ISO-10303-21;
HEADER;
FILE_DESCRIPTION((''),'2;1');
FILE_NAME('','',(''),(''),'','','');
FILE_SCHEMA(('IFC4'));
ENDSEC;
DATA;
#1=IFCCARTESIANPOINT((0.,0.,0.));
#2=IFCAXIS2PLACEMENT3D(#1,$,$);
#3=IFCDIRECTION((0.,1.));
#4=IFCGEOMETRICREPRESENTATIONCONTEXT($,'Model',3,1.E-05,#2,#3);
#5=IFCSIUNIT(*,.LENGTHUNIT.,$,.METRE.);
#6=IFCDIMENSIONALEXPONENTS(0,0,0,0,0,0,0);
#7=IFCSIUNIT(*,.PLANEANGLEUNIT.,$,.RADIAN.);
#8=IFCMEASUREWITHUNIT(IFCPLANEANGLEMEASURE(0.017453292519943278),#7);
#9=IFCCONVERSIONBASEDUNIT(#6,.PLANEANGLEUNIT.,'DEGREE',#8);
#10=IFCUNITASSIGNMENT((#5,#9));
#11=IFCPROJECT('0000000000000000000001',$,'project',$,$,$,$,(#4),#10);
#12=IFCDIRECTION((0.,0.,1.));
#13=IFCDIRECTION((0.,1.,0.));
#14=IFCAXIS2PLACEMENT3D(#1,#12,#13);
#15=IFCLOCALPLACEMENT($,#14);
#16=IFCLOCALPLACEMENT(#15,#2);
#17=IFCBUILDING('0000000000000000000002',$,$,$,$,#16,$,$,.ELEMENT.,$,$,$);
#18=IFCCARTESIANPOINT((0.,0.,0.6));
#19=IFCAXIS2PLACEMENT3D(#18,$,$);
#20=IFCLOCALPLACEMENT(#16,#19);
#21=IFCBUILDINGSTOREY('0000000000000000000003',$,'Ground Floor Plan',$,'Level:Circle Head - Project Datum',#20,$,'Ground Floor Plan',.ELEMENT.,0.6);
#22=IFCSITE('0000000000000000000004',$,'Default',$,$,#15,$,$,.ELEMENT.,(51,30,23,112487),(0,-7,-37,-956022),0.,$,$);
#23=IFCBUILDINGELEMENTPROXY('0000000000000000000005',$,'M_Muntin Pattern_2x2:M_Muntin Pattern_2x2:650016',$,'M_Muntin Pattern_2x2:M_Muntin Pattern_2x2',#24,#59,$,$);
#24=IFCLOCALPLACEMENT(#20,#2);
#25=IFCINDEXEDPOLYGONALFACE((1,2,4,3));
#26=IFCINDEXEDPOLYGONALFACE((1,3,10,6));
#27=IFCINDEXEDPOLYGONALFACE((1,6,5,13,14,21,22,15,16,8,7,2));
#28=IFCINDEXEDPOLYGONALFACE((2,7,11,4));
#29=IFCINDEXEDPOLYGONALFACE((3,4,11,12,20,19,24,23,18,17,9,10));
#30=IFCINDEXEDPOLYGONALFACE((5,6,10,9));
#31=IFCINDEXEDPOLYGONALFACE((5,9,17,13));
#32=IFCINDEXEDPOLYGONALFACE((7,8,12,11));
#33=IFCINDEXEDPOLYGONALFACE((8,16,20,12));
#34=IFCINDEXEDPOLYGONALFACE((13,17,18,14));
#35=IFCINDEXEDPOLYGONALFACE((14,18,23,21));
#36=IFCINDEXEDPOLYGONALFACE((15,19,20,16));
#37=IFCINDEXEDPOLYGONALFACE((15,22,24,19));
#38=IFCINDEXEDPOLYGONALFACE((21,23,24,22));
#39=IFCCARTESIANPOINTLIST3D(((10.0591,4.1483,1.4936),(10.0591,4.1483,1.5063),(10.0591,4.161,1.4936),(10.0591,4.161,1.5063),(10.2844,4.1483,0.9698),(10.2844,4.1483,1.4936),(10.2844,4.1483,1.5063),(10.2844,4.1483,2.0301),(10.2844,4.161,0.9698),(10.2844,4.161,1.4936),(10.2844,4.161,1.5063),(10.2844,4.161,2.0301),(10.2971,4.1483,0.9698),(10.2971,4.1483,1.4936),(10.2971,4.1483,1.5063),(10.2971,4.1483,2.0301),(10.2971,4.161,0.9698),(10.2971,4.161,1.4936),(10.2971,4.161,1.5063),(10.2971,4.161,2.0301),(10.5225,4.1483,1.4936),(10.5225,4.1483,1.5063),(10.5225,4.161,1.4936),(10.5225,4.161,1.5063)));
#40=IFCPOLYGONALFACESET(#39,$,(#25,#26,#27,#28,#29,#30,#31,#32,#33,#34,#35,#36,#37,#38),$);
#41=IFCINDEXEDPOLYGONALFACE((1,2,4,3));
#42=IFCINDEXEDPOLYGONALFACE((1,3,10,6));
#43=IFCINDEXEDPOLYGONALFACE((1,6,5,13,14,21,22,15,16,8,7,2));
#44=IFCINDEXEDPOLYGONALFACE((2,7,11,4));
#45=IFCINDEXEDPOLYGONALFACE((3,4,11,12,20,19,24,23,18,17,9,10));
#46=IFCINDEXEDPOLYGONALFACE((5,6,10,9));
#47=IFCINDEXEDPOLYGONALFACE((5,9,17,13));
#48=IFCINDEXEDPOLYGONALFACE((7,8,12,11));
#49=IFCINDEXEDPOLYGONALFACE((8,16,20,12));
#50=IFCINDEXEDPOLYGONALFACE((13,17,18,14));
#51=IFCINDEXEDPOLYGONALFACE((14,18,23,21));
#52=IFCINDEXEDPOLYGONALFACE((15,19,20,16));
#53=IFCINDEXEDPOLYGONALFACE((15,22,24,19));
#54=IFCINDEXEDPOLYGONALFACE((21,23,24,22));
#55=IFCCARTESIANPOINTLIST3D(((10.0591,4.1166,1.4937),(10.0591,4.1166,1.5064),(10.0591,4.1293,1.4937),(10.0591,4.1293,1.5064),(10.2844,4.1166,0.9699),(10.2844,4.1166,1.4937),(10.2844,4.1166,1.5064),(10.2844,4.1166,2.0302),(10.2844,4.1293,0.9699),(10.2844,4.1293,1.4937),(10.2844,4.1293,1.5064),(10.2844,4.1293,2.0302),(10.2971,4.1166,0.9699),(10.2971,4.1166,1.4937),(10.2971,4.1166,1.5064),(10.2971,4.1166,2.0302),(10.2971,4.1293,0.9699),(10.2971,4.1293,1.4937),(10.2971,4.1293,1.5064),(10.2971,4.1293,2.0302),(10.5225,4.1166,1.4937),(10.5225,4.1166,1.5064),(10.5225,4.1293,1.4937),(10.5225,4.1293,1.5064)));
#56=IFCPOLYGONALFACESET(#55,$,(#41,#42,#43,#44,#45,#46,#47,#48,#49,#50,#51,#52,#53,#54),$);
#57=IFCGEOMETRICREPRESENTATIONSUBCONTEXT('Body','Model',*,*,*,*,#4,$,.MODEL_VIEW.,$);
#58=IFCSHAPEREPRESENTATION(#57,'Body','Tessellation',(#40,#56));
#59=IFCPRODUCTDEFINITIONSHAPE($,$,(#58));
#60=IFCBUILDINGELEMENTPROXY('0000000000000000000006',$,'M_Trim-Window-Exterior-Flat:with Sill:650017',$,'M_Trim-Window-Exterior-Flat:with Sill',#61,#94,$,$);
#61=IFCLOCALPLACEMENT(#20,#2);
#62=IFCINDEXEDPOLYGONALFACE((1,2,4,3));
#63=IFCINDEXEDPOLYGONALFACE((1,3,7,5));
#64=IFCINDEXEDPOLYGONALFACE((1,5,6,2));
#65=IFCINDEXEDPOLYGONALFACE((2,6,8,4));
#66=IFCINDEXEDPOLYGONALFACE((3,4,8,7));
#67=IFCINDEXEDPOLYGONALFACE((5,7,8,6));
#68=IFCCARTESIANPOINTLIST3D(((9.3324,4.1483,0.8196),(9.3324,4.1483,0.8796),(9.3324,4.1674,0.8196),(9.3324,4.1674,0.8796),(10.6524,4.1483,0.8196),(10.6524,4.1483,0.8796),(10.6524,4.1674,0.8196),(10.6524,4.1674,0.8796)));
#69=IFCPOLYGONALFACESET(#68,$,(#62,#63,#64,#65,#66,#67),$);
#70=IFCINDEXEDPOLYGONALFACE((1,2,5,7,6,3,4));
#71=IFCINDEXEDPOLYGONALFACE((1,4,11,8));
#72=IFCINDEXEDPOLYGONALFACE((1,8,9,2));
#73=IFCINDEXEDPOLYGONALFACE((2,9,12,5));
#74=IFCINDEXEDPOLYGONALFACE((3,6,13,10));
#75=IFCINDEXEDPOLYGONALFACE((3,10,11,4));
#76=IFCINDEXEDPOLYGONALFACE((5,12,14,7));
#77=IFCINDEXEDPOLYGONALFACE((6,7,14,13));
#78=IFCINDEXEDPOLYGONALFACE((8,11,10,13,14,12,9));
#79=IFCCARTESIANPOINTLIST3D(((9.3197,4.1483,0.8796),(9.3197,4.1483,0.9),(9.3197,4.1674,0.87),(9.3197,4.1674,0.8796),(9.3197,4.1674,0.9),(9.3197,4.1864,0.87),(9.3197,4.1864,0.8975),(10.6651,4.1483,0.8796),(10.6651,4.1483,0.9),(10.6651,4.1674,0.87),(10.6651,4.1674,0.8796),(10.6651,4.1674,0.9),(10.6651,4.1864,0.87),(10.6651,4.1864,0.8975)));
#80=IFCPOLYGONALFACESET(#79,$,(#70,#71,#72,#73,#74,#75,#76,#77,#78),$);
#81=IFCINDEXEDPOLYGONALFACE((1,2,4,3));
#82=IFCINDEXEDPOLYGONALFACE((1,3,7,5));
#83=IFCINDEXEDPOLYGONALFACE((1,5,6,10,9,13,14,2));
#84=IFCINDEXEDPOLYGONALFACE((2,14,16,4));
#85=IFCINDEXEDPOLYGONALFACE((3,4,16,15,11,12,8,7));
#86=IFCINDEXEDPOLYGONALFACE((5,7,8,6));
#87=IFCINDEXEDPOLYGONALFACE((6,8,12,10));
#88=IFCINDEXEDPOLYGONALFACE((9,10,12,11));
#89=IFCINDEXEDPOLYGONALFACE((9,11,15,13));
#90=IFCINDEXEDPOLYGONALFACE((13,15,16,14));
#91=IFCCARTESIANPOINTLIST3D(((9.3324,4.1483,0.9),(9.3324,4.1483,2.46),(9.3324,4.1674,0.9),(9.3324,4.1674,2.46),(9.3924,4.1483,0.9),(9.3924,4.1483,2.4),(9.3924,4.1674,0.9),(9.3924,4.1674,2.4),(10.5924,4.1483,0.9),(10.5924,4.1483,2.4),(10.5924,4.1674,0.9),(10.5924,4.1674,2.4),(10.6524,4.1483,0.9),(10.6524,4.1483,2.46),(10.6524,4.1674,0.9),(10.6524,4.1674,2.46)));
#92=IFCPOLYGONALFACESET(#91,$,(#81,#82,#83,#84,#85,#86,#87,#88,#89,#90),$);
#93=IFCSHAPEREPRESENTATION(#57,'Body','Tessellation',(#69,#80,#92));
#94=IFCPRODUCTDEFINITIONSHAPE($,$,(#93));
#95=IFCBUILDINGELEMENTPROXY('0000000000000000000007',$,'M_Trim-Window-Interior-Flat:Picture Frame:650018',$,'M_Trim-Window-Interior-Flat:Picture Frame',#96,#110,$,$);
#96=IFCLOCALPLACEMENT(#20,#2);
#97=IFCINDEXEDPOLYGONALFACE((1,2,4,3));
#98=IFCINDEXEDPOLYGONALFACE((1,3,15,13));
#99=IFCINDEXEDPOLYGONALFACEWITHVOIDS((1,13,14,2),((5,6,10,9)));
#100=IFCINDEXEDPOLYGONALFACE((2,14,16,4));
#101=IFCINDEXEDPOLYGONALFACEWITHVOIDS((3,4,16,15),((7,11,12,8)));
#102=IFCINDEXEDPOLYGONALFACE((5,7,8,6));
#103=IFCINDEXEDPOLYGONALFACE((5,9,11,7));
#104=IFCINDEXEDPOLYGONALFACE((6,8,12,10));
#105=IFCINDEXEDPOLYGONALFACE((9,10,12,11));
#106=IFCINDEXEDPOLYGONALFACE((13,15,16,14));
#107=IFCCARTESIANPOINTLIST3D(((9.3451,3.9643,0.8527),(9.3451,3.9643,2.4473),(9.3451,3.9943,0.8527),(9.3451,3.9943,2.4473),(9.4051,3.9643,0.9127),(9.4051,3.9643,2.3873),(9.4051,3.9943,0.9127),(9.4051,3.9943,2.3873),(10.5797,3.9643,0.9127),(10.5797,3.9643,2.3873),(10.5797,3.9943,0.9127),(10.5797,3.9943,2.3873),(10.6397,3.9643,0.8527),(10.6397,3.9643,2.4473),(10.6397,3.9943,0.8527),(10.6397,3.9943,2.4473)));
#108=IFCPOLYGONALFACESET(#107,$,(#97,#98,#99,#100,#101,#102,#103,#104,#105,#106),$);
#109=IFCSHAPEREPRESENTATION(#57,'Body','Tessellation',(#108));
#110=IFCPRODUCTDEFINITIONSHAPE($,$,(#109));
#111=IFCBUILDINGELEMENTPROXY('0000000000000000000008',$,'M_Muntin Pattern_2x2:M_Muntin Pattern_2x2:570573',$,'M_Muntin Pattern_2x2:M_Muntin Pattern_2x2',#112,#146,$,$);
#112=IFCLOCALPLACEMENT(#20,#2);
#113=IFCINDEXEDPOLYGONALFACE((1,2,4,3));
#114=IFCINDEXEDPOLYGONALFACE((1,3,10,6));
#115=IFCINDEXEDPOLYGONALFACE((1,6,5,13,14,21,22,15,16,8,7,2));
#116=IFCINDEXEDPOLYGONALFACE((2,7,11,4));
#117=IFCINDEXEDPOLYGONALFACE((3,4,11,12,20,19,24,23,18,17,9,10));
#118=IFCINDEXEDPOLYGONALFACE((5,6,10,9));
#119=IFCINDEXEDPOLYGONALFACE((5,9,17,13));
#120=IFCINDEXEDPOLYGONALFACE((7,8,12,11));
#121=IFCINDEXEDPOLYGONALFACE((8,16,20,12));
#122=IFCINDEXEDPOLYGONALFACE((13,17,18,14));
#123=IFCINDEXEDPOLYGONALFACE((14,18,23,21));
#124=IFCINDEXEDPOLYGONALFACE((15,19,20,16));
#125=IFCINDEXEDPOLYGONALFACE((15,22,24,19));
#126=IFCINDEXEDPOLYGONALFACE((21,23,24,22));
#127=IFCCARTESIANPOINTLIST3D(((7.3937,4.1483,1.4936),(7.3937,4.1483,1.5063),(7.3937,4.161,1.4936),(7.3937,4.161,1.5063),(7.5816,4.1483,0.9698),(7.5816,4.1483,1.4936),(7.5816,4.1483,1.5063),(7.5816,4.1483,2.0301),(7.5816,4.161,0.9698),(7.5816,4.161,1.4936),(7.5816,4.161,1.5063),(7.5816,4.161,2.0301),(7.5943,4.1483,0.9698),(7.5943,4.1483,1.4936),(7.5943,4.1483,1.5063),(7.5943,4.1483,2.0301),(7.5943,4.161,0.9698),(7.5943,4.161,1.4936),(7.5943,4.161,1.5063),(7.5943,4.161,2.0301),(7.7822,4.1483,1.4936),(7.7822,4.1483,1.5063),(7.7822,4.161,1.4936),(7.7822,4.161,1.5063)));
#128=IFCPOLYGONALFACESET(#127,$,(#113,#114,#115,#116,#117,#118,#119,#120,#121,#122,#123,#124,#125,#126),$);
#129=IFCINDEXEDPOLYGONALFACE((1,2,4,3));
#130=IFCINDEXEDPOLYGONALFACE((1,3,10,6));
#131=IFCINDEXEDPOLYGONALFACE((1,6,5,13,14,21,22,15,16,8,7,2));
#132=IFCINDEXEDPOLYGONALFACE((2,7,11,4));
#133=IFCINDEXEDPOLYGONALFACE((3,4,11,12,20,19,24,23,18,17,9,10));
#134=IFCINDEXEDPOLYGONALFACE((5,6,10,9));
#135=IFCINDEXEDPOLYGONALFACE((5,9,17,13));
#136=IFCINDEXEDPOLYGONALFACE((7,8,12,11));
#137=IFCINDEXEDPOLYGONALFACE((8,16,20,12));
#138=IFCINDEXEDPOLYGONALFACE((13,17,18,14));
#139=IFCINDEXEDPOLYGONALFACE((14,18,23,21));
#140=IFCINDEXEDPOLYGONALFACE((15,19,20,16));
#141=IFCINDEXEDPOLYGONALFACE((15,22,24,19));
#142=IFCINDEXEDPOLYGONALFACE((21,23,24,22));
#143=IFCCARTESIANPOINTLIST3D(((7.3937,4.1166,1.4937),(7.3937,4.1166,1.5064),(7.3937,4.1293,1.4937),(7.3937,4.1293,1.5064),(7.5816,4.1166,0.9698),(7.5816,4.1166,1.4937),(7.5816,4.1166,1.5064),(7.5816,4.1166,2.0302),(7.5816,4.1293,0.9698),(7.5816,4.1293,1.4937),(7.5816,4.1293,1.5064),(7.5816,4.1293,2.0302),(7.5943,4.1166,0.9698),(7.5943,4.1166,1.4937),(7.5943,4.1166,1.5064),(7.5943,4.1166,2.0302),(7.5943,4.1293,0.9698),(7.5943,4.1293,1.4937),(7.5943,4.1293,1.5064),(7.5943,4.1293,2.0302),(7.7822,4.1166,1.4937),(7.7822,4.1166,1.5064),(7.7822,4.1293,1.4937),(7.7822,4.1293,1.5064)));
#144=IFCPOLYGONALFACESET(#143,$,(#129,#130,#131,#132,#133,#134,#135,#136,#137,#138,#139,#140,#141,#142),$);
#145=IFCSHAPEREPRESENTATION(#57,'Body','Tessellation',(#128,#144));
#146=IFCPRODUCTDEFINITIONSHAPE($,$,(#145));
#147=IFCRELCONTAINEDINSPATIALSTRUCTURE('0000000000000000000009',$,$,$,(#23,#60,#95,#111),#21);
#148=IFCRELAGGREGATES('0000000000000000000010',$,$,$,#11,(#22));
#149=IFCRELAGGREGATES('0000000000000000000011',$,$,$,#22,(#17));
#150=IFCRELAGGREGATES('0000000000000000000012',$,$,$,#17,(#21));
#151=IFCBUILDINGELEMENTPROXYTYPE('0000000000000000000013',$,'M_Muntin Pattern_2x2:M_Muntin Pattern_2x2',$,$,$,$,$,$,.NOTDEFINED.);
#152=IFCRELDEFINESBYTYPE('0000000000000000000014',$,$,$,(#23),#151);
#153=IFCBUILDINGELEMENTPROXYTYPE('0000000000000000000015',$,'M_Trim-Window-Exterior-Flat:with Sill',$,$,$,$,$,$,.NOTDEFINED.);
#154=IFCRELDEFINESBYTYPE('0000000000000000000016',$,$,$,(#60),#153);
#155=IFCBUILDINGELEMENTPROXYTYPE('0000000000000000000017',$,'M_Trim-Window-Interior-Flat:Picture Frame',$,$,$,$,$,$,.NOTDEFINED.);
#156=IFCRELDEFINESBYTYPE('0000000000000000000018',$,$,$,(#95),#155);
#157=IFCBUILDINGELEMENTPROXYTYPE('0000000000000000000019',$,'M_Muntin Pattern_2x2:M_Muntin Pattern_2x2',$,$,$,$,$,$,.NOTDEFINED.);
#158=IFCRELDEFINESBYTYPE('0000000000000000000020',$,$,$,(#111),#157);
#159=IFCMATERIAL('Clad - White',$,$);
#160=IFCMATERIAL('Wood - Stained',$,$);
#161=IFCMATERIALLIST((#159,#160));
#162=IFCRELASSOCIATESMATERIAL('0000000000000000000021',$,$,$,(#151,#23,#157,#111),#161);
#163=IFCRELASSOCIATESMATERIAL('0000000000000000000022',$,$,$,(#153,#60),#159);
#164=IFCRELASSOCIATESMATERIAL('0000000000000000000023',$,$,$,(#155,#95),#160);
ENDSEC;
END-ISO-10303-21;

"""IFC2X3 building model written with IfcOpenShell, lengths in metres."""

from ifc_helpers import new_model, entity, si_unit, converted_unit, direction, frame, frame_2d, origin, place, context, subcontext, project, spatial, polyline, rectangle, outline, extrude, source, transform, mapped, material, material_list, type_object, type_shapes, element, save


model = new_model("IFC2X3")

# Units and contexts
model_context = context("Model", 3, precision=1e-05, world=origin(), true_north=direction((0.0, 1.0)))
body_context = subcontext(model_context, "Body", "Model", "MODEL_VIEW")
ifc_project = project(units=[si_unit("LENGTHUNIT", "METRE"), converted_unit("PLANEANGLEUNIT", "DEGREE", entity("IfcPlaneAngleMeasure", 0.017453292519943278), si_unit("PLANEANGLEUNIT", "RADIAN"), dimensions=[0, 0, 0, 0, 0, 0, 0])], contexts=[model_context])

# Site, building, storey
site_placement = place(None, frame((0.0, 0.0, 0.0), z_axis=(0.0, 0.0, 1.0), x_axis=(0.0, 1.0, 0.0)))
site = spatial("IfcSite", under=ifc_project, at=site_placement, Name="Default", CompositionType="ELEMENT", RefLatitude=(51, 30, 23, 112487), RefLongitude=(0, -7, -37, -956022), RefElevation=0.0)
building_placement = place(site_placement, origin())
building = spatial("IfcBuilding", under=site, at=building_placement, CompositionType="ELEMENT")
storey_placement = place(building_placement, frame((0.0, 0.0, 0.6)))
storey = spatial("IfcBuildingStorey", under=building, at=storey_placement, Name="Ground Floor Plan", ObjectType="Level:Circle Head - Project Datum", LongName="Ground Floor Plan", CompositionType="ELEMENT", Elevation=0.6)

# Building element proxies
ifc_material_1 = material(Name="Clad - White")
ifc_material_2 = material(Name="Wood - Stained")
ifc_material_list = material_list([ifc_material_1, ifc_material_2])
building_element_proxy_type_1 = type_object("IfcBuildingElementProxyType", Name="M_Muntin Pattern_2x2:M_Muntin Pattern_2x2", PredefinedType="NOTDEFINED", material=ifc_material_list)
shared_shape_1 = source(origin(), body_context, "Body", "SweptSolid", [
    extrude(outline(polyline([(0.0064, -0.0064), (0.5301, -0.0064), (0.5301, 0.0063), (0.0064, 0.0063), (0.0064, 0.2317), (-0.0063, 0.2317), (-0.0063, 0.0063), (-0.5302, 0.0063), (-0.5302, -0.0064), (-0.0063, -0.0064), (-0.0063, -0.2317), (0.0064, -0.2317), (0.0064, -0.0064)])), frame((0.0, -0.0222, 0.5301), z_axis=(0.0, 1.0, 0.0), x_axis=(0.0, 0.0, 1.0)), (0.0, 0.0, 1.0), 0.0127),
    extrude(outline(polyline([(0.0064, -0.0064), (0.5302, -0.0064), (0.5302, 0.0063), (0.0064, 0.0063), (0.0064, 0.2317), (-0.0063, 0.2317), (-0.0063, 0.0063), (-0.5302, 0.0063), (-0.5302, -0.0064), (-0.0063, -0.0064), (-0.0063, -0.2317), (0.0064, -0.2317), (0.0064, -0.0064)])), frame((0.0, 0.0095, 0.5302), z_axis=(0.0, 1.0, 0.0), x_axis=(0.0, 0.0, 1.0)), (0.0, 0.0, 1.0), 0.0127),
])
type_shapes(building_element_proxy_type_1, [shared_shape_1])
proxy_1_placement = place(storey_placement, frame((10.2908, 4.1388, 0.9699), z_axis=(0.0, 0.0, 1.0), x_axis=(-1.0, 0.0, 0.0)))
element("IfcBuildingElementProxy", 1, at=proxy_1_placement, inside=storey, type_object=building_element_proxy_type_1, material=ifc_material_list, Name="M_Muntin Pattern_2x2:M_Muntin Pattern_2x2:650016", ObjectType="M_Muntin Pattern_2x2:M_Muntin Pattern_2x2", context=body_context, shape_type="MappedRepresentation", body=[
    mapped(shared_shape_1, transform((0.0, 0.0, 0.0), scale=1.0)),
])
building_element_proxy_type_2 = type_object("IfcBuildingElementProxyType", Name="M_Trim-Window-Exterior-Flat:with Sill", PredefinedType="NOTDEFINED", material=ifc_material_1)
shared_shape_2 = source(origin(), body_context, "Body", "SweptSolid", [
    extrude(rectangle(XDim=1.32, YDim=0.06, at=frame_2d((0.0, 0.0), x_axis=(1.0, 0.0))), frame((0.0, -1.5504, 0.0), z_axis=(0.0, 0.0, 1.0), x_axis=(-1.0, 0.0, 0.0)), (0.0, 0.0, 1.0), 0.019),
    extrude(outline(polyline([(-0.019, -0.0152), (0.0, -0.0152), (0.0, -0.0057), (0.019, -0.0057), (0.019, 0.0148), (0.0, 0.0148), (-0.019, 0.0123), (-0.019, -0.0152)])), frame((-0.6727, -1.5148, 0.019), z_axis=(1.0, 0.0, 0.0), x_axis=(0.0, 0.0, -1.0)), (0.0, 0.0, 1.0), 1.3454),
    extrude(outline(polyline([(-0.795, -0.66), (0.765, -0.66), (0.765, -0.6), (-0.735, -0.6), (-0.735, 0.6), (0.765, 0.6), (0.765, 0.66), (-0.795, 0.66), (-0.795, -0.66)])), frame((0.0, -0.735, 0.0), z_axis=(0.0, 0.0, 1.0), x_axis=(0.0, -1.0, 0.0)), (0.0, 0.0, 1.0), 0.019),
])
type_shapes(building_element_proxy_type_2, [shared_shape_2])
proxy_2_placement = place(storey_placement, frame((9.9924, 4.1483, 2.4), z_axis=(0.0, 1.0, 0.0), x_axis=(-1.0, 0.0, 0.0)))
element("IfcBuildingElementProxy", 2, at=proxy_2_placement, inside=storey, type_object=building_element_proxy_type_2, material=ifc_material_1, Name="M_Trim-Window-Exterior-Flat:with Sill:650017", ObjectType="M_Trim-Window-Exterior-Flat:with Sill", context=body_context, shape_type="MappedRepresentation", body=[
    mapped(shared_shape_2, transform((0.0, 0.0, 0.0), scale=1.0)),
])
building_element_proxy_type_3 = type_object("IfcBuildingElementProxyType", Name="M_Trim-Window-Interior-Flat:Picture Frame", PredefinedType="NOTDEFINED", material=ifc_material_2)
shared_shape_3 = source(origin(), body_context, "Body", "SweptSolid", [
    extrude(outline(polyline([(-0.6473, -0.7973), (0.6473, -0.7973), (0.6473, 0.7973), (-0.6473, 0.7973), (-0.6473, -0.7973)]), holes=[polyline([(-0.5873, -0.7373), (-0.5873, 0.7373), (0.5873, 0.7373), (0.5873, -0.7373), (-0.5873, -0.7373)])]), frame((0.0, -0.75, 0.0), z_axis=(0.0, 0.0, 1.0), x_axis=(-1.0, 0.0, 0.0)), (0.0, 0.0, 1.0), 0.03),
])
type_shapes(building_element_proxy_type_3, [shared_shape_3])
proxy_3_placement = place(storey_placement, frame((9.9924, 3.9943, 2.4), z_axis=(0.0, -1.0, 0.0), x_axis=(1.0, 0.0, 0.0)))
element("IfcBuildingElementProxy", 3, at=proxy_3_placement, inside=storey, type_object=building_element_proxy_type_3, material=ifc_material_2, Name="M_Trim-Window-Interior-Flat:Picture Frame:650018", ObjectType="M_Trim-Window-Interior-Flat:Picture Frame", context=body_context, shape_type="MappedRepresentation", body=[
    mapped(shared_shape_3, transform((0.0, 0.0, 0.0), scale=1.0)),
])
building_element_proxy_type_4 = type_object("IfcBuildingElementProxyType", Name="M_Muntin Pattern_2x2:M_Muntin Pattern_2x2", PredefinedType="NOTDEFINED", material=ifc_material_list)
shared_shape_4 = source(origin(), body_context, "Body", "SweptSolid", [
    extrude(outline(polyline([(0.0064, -0.0064), (0.5301, -0.0064), (0.5301, 0.0063), (0.0064, 0.0063), (0.0064, 0.1942), (-0.0063, 0.1942), (-0.0063, 0.0063), (-0.5302, 0.0063), (-0.5302, -0.0064), (-0.0063, -0.0064), (-0.0063, -0.1942), (0.0064, -0.1942), (0.0064, -0.0064)])), frame((0.0, 0.0095, 0.5301), z_axis=(0.0, 1.0, 0.0), x_axis=(0.0, 0.0, 1.0)), (0.0, 0.0, 1.0), 0.0127),
    extrude(outline(polyline([(0.0064, -0.0064), (0.5302, -0.0064), (0.5302, 0.0063), (0.0064, 0.0063), (0.0064, 0.1942), (-0.0063, 0.1942), (-0.0063, 0.0063), (-0.5302, 0.0063), (-0.5302, -0.0064), (-0.0063, -0.0064), (-0.0063, -0.1942), (0.0064, -0.1942), (0.0064, -0.0064)])), frame((0.0, -0.0222, 0.5302), z_axis=(0.0, 1.0, 0.0), x_axis=(0.0, 0.0, 1.0)), (0.0, 0.0, 1.0), 0.0127),
])
type_shapes(building_element_proxy_type_4, [shared_shape_4])
proxy_4_placement = place(storey_placement, frame((7.5879, 4.1388, 0.9698)))
element("IfcBuildingElementProxy", 4, at=proxy_4_placement, inside=storey, type_object=building_element_proxy_type_4, material=ifc_material_list, Name="M_Muntin Pattern_2x2:M_Muntin Pattern_2x2:570573", ObjectType="M_Muntin Pattern_2x2:M_Muntin Pattern_2x2", context=body_context, shape_type="MappedRepresentation", body=[
    mapped(shared_shape_4, transform((0.0, 0.0, 0.0), scale=1.0)),
])

save(model, "model.ifc")
